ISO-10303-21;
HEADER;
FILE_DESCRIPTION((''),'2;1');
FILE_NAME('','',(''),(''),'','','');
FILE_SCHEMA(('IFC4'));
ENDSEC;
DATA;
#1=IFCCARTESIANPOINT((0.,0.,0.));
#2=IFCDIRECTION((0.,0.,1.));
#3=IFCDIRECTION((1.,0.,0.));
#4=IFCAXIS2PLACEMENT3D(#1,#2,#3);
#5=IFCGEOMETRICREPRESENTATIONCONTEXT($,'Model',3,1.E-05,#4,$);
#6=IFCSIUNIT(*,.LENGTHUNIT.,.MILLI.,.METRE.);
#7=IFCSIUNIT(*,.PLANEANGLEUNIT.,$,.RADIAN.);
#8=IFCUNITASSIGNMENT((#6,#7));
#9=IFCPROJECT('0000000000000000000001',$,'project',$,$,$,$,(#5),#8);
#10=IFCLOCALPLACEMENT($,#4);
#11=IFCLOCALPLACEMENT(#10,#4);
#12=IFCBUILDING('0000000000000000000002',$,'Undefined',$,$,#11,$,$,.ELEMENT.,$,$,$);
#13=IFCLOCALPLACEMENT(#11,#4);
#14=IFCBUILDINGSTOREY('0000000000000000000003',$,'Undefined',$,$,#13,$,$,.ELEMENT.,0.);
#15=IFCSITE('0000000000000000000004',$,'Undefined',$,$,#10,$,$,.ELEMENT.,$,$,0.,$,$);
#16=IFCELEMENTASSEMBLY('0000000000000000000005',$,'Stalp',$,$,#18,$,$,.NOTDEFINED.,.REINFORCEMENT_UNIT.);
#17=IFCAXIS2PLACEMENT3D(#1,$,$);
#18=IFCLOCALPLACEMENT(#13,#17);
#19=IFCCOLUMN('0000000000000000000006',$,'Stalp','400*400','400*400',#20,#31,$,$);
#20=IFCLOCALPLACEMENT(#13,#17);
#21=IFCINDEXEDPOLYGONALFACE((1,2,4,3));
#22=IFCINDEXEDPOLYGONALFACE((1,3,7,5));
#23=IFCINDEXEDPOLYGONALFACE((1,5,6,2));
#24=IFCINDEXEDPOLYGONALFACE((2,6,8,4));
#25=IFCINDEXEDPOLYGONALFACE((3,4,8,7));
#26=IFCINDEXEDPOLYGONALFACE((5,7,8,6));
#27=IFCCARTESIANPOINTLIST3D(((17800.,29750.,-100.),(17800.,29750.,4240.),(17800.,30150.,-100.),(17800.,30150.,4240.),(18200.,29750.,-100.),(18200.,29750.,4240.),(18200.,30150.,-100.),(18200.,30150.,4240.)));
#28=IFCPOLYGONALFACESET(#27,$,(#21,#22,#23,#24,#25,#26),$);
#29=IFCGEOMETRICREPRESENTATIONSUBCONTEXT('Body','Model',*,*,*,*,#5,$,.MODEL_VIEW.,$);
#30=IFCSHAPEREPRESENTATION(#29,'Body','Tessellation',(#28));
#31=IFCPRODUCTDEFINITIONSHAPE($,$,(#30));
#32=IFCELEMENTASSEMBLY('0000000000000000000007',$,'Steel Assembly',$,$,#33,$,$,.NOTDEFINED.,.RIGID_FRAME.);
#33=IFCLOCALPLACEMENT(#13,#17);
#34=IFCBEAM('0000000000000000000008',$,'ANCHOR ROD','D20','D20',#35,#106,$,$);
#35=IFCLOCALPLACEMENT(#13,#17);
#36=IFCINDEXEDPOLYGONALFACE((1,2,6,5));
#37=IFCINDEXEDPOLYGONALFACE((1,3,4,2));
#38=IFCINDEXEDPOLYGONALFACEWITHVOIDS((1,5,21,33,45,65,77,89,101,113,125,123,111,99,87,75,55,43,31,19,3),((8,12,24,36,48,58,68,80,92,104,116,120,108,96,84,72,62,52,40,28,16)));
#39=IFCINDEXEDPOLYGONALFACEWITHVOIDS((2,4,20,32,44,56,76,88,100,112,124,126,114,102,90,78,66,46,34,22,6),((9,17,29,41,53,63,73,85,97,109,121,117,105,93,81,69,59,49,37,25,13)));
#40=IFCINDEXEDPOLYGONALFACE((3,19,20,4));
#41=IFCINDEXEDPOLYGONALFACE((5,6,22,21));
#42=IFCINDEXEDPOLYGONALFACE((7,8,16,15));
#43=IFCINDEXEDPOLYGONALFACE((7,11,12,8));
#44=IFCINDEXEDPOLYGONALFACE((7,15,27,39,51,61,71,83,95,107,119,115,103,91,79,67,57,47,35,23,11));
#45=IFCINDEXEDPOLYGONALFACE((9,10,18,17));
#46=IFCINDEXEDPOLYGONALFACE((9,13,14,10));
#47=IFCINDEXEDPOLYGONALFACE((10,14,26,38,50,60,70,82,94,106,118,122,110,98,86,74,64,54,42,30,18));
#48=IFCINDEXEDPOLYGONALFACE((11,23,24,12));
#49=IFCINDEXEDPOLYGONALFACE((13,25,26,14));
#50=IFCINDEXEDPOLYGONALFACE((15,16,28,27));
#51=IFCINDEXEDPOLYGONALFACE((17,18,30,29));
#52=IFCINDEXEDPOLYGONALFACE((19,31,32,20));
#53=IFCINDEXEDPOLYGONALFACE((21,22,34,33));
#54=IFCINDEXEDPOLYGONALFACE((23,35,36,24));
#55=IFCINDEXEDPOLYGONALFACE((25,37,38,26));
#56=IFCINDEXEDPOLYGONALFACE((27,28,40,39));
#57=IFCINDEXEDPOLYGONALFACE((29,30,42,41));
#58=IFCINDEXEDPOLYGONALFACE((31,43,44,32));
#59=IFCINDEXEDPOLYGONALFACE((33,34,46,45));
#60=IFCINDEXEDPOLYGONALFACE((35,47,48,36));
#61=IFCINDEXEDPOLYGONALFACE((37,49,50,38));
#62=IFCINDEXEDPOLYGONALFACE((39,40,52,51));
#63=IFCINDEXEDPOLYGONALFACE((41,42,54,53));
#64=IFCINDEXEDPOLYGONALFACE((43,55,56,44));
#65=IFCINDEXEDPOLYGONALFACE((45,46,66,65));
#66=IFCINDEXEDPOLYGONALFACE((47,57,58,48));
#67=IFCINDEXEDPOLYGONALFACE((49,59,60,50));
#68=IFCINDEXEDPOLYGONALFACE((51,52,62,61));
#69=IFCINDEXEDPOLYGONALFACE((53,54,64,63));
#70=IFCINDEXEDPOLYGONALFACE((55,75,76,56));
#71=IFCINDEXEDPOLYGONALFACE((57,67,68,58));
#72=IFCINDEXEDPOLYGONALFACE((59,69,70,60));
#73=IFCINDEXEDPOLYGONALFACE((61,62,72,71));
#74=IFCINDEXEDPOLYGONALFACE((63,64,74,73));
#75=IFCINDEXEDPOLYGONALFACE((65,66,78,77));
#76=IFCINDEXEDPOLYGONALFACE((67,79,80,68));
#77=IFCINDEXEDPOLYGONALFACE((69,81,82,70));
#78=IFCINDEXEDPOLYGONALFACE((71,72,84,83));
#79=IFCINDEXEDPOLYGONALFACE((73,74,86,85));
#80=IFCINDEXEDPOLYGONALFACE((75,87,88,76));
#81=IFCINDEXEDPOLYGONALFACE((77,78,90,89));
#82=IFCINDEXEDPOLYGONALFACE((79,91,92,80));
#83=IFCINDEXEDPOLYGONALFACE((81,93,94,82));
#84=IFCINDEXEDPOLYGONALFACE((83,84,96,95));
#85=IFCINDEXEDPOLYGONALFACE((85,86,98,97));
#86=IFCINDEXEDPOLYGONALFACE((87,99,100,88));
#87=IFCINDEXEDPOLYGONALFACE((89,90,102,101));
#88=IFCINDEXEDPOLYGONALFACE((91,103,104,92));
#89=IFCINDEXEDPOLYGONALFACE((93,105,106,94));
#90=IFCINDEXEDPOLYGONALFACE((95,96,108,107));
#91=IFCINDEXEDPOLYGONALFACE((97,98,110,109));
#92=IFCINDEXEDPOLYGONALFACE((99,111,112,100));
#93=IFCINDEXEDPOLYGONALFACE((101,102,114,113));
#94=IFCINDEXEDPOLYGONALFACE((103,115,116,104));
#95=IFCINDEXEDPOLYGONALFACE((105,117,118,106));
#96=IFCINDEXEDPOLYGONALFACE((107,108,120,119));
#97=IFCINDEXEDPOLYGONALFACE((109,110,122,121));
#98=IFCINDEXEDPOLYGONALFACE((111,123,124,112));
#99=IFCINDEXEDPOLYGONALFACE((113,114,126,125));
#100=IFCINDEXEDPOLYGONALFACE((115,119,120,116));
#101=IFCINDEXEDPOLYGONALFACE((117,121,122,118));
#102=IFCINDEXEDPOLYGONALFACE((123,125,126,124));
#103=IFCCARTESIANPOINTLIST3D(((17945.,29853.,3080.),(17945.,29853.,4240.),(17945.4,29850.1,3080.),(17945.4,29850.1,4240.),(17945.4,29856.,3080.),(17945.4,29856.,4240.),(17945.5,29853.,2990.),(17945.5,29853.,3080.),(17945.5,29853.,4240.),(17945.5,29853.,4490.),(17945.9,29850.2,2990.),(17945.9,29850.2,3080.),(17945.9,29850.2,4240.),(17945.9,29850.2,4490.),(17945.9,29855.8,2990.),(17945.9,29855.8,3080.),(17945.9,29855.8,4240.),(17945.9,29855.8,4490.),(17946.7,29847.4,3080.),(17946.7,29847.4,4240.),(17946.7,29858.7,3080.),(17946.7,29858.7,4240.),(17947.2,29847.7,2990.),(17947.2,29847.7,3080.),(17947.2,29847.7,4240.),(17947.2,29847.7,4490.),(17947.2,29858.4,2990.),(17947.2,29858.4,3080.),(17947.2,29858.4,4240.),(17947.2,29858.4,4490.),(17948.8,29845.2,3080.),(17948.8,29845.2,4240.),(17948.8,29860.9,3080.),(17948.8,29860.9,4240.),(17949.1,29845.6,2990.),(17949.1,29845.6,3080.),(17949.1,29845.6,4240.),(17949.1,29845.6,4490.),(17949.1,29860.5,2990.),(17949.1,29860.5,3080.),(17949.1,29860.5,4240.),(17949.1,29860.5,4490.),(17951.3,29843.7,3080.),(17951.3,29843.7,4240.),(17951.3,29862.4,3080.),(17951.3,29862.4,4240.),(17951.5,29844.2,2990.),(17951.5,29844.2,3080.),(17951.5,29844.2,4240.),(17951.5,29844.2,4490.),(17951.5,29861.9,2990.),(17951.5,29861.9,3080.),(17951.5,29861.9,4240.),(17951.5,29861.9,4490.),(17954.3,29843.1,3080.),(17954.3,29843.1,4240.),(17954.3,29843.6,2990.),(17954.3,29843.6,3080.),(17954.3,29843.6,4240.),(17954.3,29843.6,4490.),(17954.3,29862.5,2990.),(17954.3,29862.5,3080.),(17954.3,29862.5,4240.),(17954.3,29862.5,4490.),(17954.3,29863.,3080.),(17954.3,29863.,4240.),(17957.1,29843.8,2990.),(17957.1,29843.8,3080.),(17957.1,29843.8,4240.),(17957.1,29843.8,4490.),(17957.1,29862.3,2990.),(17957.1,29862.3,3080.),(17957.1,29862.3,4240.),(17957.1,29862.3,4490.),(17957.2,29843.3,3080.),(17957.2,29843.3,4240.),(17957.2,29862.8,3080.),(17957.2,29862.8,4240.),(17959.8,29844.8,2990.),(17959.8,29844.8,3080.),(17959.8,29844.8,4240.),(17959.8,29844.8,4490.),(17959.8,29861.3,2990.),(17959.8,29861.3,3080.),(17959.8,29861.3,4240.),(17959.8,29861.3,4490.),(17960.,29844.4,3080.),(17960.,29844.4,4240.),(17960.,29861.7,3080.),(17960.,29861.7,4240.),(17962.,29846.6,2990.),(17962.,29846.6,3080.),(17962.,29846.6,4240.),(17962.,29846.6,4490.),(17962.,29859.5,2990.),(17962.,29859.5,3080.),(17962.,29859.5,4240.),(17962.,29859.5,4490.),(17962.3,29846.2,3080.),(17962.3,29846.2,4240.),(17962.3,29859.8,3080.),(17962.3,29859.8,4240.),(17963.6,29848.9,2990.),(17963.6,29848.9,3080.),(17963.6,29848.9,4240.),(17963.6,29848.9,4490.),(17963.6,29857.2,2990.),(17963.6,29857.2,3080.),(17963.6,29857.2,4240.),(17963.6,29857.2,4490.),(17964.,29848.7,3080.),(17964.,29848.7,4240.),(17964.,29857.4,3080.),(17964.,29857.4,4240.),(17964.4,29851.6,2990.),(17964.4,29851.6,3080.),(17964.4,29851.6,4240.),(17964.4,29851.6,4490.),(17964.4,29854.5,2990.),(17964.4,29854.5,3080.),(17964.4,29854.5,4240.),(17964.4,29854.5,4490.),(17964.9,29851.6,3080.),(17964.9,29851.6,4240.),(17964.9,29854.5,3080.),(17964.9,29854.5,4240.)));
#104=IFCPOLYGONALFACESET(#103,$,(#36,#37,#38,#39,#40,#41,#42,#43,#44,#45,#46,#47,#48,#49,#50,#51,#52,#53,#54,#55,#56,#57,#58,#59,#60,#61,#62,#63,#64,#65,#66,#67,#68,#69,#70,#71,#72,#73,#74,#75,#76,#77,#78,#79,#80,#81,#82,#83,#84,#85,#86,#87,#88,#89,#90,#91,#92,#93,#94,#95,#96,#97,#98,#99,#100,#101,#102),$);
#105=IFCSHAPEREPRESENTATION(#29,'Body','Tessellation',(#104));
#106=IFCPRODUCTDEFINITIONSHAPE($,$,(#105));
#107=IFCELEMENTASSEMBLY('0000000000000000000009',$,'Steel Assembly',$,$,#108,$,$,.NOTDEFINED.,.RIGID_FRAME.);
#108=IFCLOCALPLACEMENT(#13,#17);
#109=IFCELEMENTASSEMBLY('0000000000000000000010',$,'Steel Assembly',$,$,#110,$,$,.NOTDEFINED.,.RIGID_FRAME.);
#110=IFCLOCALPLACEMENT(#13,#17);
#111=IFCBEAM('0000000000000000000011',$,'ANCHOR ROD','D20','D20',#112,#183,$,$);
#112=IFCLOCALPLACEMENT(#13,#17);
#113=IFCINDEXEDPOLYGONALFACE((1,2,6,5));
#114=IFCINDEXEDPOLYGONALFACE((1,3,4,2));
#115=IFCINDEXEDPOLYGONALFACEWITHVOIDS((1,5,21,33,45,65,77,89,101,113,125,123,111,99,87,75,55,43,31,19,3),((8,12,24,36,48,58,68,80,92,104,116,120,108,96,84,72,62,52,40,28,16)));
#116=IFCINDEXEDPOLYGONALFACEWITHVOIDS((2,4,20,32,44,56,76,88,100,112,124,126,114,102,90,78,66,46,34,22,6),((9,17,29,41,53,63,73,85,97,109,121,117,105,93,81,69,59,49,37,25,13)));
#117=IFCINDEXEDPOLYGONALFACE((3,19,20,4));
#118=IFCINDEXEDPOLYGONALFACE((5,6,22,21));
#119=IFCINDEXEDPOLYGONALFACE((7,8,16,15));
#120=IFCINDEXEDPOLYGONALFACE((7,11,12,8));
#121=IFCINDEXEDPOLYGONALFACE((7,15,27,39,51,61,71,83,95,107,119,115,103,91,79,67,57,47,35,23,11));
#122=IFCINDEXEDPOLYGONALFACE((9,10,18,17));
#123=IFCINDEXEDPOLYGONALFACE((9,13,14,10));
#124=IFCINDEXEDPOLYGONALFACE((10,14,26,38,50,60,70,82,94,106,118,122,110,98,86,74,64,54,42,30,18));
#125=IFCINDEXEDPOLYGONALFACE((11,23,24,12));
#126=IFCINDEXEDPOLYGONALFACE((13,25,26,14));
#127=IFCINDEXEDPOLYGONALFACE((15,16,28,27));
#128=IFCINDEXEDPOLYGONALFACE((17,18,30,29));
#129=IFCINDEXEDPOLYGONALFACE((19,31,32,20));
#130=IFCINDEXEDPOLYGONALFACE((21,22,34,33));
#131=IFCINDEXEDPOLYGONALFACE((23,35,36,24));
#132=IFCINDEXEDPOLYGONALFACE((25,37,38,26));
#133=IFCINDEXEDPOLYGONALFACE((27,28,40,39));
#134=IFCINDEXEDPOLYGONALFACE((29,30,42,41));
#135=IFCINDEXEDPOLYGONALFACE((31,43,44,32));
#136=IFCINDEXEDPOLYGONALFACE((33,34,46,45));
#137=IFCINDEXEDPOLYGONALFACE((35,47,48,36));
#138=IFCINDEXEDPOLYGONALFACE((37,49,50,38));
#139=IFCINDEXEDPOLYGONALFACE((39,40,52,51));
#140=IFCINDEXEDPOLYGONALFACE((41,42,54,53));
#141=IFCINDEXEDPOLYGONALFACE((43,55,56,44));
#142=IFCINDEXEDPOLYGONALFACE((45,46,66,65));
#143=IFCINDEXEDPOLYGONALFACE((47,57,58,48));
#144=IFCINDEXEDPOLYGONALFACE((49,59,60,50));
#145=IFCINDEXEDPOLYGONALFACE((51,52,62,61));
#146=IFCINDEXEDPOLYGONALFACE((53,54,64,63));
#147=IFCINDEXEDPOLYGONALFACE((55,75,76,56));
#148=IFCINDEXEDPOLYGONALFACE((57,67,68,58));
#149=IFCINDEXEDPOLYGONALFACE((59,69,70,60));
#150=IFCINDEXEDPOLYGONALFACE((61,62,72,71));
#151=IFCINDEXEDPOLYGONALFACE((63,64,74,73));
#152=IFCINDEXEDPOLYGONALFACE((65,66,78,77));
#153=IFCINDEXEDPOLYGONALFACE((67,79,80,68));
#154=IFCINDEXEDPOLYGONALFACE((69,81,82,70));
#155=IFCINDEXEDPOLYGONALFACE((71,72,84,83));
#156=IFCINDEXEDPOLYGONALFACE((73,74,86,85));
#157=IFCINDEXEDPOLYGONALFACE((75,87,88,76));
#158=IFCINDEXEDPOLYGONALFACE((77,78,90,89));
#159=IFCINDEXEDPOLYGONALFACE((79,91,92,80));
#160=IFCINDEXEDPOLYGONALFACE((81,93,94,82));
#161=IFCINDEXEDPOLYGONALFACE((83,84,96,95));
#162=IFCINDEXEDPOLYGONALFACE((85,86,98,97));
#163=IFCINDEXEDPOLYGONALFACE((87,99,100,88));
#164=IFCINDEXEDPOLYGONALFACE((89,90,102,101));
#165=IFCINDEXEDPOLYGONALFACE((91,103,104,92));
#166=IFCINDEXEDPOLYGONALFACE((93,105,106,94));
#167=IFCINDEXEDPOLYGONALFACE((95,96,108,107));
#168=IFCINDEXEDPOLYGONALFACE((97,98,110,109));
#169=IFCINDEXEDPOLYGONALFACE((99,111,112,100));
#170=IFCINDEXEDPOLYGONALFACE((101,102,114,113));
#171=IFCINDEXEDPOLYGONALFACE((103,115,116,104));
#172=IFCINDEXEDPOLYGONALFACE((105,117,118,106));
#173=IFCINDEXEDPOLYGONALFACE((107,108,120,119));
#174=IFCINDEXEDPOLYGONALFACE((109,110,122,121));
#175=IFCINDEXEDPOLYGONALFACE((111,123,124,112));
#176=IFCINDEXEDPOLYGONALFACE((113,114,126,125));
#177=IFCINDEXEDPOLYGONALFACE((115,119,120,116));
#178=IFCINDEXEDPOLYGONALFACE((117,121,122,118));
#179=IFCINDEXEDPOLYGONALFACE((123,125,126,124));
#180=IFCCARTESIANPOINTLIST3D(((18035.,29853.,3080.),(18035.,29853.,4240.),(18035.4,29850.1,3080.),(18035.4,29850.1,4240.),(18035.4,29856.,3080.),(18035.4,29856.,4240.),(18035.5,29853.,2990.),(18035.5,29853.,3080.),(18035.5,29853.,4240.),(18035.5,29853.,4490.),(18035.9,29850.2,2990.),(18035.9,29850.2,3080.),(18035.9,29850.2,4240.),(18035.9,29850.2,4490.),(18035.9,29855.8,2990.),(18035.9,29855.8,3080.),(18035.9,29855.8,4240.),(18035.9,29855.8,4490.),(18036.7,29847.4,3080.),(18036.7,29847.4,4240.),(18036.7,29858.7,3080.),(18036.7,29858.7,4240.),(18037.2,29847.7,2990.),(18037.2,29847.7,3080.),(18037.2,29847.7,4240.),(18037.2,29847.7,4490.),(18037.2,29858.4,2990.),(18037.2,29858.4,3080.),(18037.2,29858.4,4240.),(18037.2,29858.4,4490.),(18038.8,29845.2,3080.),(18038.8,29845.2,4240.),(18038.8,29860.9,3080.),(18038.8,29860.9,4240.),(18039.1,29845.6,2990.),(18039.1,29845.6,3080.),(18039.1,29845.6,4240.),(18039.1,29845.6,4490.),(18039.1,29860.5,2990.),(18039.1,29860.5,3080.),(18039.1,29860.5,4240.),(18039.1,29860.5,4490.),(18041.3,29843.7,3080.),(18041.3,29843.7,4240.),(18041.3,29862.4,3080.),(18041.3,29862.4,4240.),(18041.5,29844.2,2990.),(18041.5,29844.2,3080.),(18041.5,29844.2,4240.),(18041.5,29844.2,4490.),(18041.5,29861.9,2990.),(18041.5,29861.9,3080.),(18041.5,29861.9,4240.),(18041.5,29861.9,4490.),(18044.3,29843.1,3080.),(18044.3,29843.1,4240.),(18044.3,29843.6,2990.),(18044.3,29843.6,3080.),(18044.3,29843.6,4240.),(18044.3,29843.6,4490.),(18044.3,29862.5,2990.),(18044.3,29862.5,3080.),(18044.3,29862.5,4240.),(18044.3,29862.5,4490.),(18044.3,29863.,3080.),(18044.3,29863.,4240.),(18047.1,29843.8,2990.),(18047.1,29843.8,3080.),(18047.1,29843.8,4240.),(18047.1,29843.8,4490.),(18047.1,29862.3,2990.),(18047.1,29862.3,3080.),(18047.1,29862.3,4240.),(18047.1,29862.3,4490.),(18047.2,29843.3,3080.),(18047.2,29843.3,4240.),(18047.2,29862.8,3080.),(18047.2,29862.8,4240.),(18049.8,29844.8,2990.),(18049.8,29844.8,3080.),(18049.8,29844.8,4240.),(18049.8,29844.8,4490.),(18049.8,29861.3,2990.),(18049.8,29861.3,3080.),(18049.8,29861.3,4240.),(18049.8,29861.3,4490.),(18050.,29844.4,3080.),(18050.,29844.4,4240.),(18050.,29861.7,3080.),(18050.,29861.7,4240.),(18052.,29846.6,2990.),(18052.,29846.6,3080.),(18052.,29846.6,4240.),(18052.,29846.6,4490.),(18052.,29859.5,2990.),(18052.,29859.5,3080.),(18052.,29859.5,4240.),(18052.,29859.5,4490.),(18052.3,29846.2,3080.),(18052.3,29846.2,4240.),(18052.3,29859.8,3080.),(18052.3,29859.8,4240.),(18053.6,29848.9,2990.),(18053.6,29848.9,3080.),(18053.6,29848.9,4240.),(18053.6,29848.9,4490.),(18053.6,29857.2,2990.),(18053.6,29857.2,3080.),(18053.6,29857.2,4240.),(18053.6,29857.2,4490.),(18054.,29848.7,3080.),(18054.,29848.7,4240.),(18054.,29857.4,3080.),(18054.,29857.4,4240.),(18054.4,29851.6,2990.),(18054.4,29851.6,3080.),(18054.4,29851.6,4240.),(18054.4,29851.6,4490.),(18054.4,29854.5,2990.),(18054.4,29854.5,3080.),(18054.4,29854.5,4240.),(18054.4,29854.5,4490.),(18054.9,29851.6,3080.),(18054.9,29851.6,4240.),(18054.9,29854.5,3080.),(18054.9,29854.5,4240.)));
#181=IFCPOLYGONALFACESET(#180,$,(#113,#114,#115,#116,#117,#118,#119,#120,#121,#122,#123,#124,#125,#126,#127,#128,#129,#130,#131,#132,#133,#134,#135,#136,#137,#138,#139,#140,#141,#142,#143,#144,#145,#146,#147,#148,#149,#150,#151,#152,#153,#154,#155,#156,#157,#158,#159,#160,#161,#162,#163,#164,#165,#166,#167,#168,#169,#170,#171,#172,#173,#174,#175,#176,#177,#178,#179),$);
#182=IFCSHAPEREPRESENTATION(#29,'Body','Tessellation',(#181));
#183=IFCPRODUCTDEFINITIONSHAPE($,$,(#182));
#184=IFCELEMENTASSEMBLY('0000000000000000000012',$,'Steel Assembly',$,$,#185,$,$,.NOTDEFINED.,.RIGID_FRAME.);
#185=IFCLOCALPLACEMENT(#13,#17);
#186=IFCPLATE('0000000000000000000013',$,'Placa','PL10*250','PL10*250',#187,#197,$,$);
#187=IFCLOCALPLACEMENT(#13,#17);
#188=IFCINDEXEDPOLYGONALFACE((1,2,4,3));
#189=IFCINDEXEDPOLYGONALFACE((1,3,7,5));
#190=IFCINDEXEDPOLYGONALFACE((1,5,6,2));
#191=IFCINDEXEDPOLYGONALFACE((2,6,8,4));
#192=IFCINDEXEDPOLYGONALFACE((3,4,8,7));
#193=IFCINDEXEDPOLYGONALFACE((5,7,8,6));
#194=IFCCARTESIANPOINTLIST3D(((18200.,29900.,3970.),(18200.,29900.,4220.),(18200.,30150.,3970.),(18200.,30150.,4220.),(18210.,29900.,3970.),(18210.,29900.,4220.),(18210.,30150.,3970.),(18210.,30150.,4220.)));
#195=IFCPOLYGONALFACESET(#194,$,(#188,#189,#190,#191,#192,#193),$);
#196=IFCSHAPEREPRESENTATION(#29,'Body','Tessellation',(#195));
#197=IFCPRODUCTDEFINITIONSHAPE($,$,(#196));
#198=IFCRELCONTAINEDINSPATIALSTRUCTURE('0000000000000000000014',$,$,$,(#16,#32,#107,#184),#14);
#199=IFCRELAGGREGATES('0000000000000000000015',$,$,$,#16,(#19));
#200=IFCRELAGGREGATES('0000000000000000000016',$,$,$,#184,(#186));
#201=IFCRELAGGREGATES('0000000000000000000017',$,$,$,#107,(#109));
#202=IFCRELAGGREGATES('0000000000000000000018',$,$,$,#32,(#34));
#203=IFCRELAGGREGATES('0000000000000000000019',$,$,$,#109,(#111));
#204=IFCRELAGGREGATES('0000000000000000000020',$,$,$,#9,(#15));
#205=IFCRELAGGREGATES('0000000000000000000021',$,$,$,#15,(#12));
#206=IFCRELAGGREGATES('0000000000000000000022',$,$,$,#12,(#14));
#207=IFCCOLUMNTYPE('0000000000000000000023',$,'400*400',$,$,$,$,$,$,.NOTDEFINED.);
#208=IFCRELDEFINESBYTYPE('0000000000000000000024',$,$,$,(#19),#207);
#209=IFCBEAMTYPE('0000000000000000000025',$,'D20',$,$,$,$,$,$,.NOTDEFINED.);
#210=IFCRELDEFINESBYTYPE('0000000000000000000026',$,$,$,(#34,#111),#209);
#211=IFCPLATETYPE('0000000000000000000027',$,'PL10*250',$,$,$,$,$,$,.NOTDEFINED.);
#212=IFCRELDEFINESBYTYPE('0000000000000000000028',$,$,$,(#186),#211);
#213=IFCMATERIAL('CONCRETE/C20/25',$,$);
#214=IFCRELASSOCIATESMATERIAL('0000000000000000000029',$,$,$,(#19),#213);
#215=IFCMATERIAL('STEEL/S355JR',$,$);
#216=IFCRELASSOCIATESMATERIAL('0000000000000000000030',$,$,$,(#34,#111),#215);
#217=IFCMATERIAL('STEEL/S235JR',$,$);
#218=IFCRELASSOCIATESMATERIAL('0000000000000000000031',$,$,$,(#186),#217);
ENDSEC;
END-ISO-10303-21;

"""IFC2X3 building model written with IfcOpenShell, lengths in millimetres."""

from ifc_helpers import new_model, si_unit, frame, origin_with_axes, origin_2d_with_axis, place, context, subcontext, project, spatial, polyline, rectangle, circle, outline, extrude, boolean, material, type_object, element, aggregate, save


model = new_model("IFC2X3")

# Units and contexts
model_context = context("Model", 3, precision=1e-05, world=origin_with_axes())
body_context = subcontext(model_context, "Body", "Model", "MODEL_VIEW")
ifc_project = project(units=[si_unit("LENGTHUNIT", "METRE", prefix="MILLI"), si_unit("PLANEANGLEUNIT", "RADIAN")], contexts=[model_context])

# Site, building, storey
site_placement = place(None, origin_with_axes())
site = spatial("IfcSite", under=ifc_project, at=site_placement, Name="Undefined", CompositionType="ELEMENT", RefElevation=0.0)
building_placement = place(site_placement, origin_with_axes())
building = spatial("IfcBuilding", under=site, at=building_placement, Name="Undefined", CompositionType="ELEMENT")
storey_placement = place(building_placement, origin_with_axes())
storey = spatial("IfcBuildingStorey", under=building, at=storey_placement, Name="Undefined", CompositionType="ELEMENT", Elevation=0.0)

# Element assembly, column
assembly_1_placement = place(storey_placement, origin_with_axes())
assembly_1 = element("IfcElementAssembly", 1, at=assembly_1_placement, inside=storey, Name="Stalp", AssemblyPlace="NOTDEFINED", PredefinedType="REINFORCEMENT_UNIT")
ifc_material_1 = material(Name="CONCRETE/C20/25")
column_type = type_object("IfcColumnType", Name="400*400", PredefinedType="NOTDEFINED")
column_placement = place(assembly_1_placement, frame((18000.0, 29950.0, -100.0), z_axis=(0.0, 0.0, 1.0), x_axis=(0.0, 1.0, 0.0)))
column = element("IfcColumn", 2, at=column_placement, type_object=column_type, material=ifc_material_1, Name="Stalp", Description="400*400", ObjectType="400*400", context=body_context, shape_type="SweptSolid", body=[
    extrude(rectangle(XDim=400.0, YDim=400.0, at=origin_2d_with_axis()), frame((0.0, 0.0, 4340.0), z_axis=(0.0, 0.0, -1.0), x_axis=(0.0, 1.0, 0.0)), (0.0, 0.0, 1.0), 4340.0),
])
aggregate(assembly_1, [column])

# Element assembly, beam
assembly_2_placement = place(storey_placement, origin_with_axes())
assembly_2 = element("IfcElementAssembly", 3, at=assembly_2_placement, inside=storey, Name="Steel Assembly", AssemblyPlace="NOTDEFINED", PredefinedType="RIGID_FRAME")
ifc_material_2 = material(Name="STEEL/S355JR")
beam_type = type_object("IfcBeamType", Name="D20", PredefinedType="NOTDEFINED")
beam_1_placement = place(assembly_2_placement, frame((17955.0, 29853.0, 4240.0), z_axis=(0.0, -1.0, 0.0), x_axis=(0.0, 0.0, -1.0)))
beam_1 = element("IfcBeam", 4, at=beam_1_placement, type_object=beam_type, material=ifc_material_2, Name="ANCHOR ROD", Description="D20", ObjectType="D20", context=body_context, shape_type="CSG", body=[
    boolean("UNION", boolean("UNION", extrude(circle(Radius=10.0, at=origin_2d_with_axis()), frame((1160.0, 0.0, 0.0), z_axis=(-1.0, 0.0, 0.0), x_axis=(0.0, -1.0, 0.0)), (0.0, 0.0, 1.0), 1160.0), extrude(circle(Radius=9.5, at=origin_2d_with_axis()), frame((1250.0, 0.0, 0.0), z_axis=(-1.0, 0.0, 0.0), x_axis=(0.0, -1.0, 0.0)), (0.0, 0.0, 1.0), 90.0)), extrude(circle(Radius=9.5, at=origin_2d_with_axis()), frame((0.0, 0.0, 0.0), z_axis=(-1.0, 0.0, 0.0), x_axis=(0.0, -1.0, 0.0)), (0.0, 0.0, 1.0), 250.0)),
])

# Element assemblies, beam
assembly_3_placement = place(storey_placement, origin_with_axes())
assembly_3 = element("IfcElementAssembly", 5, at=assembly_3_placement, inside=storey, Name="Steel Assembly", AssemblyPlace="NOTDEFINED", PredefinedType="RIGID_FRAME")
assembly_4_placement = place(assembly_3_placement, origin_with_axes())
assembly_4 = element("IfcElementAssembly", 6, at=assembly_4_placement, Name="Steel Assembly", AssemblyPlace="NOTDEFINED", PredefinedType="RIGID_FRAME")
beam_2_placement = place(assembly_4_placement, frame((18045.0, 29853.0, 4240.0), z_axis=(0.0, -1.0, 0.0), x_axis=(0.0, 0.0, -1.0)))
beam_2 = element("IfcBeam", 7, at=beam_2_placement, type_object=beam_type, material=ifc_material_2, Name="ANCHOR ROD", Description="D20", ObjectType="D20", context=body_context, shape_type="CSG", body=[
    boolean("UNION", boolean("UNION", extrude(circle(Radius=10.0, at=origin_2d_with_axis()), frame((1160.0, 0.0, 0.0), z_axis=(-1.0, 0.0, 0.0), x_axis=(0.0, -1.0, 0.0)), (0.0, 0.0, 1.0), 1160.0), extrude(circle(Radius=9.5, at=origin_2d_with_axis()), frame((1250.0, 0.0, 0.0), z_axis=(-1.0, 0.0, 0.0), x_axis=(0.0, -1.0, 0.0)), (0.0, 0.0, 1.0), 90.0)), extrude(circle(Radius=9.5, at=origin_2d_with_axis()), frame((0.0, 0.0, 0.0), z_axis=(-1.0, 0.0, 0.0), x_axis=(0.0, -1.0, 0.0)), (0.0, 0.0, 1.0), 250.0)),
])

# Element assembly, plate
assembly_5_placement = place(storey_placement, origin_with_axes())
assembly_5 = element("IfcElementAssembly", 8, at=assembly_5_placement, inside=storey, Name="Steel Assembly", AssemblyPlace="NOTDEFINED", PredefinedType="RIGID_FRAME")
ifc_material_3 = material(Name="STEEL/S235JR")
plate_type = type_object("IfcPlateType", Name="PL10*250", PredefinedType="NOTDEFINED")
plate_placement = place(assembly_5_placement, frame((18205.0, 29900.0, 4220.0), z_axis=(1.0, 0.0, 0.0), x_axis=(0.0, 0.0, -1.0)))
plate = element("IfcPlate", 9, at=plate_placement, type_object=plate_type, material=ifc_material_3, Name="Placa", Description="PL10*250", ObjectType="PL10*250", context=body_context, shape_type="SweptSolid", body=[
    extrude(outline(polyline([(0.0, 0.0), (250.0, 0.0), (250.0, 250.0), (0.0, 250.0), (0.0, 0.0)])), frame((0.0, 0.0, -5.0), z_axis=(0.0, 0.0, 1.0), x_axis=(1.0, 0.0, 0.0)), (0.0, 0.0, 1.0), 10.0),
])

aggregate(assembly_5, [plate])

aggregate(assembly_3, [assembly_4])

aggregate(assembly_2, [beam_1])
aggregate(assembly_4, [beam_2])

save(model, "model.ifc")
